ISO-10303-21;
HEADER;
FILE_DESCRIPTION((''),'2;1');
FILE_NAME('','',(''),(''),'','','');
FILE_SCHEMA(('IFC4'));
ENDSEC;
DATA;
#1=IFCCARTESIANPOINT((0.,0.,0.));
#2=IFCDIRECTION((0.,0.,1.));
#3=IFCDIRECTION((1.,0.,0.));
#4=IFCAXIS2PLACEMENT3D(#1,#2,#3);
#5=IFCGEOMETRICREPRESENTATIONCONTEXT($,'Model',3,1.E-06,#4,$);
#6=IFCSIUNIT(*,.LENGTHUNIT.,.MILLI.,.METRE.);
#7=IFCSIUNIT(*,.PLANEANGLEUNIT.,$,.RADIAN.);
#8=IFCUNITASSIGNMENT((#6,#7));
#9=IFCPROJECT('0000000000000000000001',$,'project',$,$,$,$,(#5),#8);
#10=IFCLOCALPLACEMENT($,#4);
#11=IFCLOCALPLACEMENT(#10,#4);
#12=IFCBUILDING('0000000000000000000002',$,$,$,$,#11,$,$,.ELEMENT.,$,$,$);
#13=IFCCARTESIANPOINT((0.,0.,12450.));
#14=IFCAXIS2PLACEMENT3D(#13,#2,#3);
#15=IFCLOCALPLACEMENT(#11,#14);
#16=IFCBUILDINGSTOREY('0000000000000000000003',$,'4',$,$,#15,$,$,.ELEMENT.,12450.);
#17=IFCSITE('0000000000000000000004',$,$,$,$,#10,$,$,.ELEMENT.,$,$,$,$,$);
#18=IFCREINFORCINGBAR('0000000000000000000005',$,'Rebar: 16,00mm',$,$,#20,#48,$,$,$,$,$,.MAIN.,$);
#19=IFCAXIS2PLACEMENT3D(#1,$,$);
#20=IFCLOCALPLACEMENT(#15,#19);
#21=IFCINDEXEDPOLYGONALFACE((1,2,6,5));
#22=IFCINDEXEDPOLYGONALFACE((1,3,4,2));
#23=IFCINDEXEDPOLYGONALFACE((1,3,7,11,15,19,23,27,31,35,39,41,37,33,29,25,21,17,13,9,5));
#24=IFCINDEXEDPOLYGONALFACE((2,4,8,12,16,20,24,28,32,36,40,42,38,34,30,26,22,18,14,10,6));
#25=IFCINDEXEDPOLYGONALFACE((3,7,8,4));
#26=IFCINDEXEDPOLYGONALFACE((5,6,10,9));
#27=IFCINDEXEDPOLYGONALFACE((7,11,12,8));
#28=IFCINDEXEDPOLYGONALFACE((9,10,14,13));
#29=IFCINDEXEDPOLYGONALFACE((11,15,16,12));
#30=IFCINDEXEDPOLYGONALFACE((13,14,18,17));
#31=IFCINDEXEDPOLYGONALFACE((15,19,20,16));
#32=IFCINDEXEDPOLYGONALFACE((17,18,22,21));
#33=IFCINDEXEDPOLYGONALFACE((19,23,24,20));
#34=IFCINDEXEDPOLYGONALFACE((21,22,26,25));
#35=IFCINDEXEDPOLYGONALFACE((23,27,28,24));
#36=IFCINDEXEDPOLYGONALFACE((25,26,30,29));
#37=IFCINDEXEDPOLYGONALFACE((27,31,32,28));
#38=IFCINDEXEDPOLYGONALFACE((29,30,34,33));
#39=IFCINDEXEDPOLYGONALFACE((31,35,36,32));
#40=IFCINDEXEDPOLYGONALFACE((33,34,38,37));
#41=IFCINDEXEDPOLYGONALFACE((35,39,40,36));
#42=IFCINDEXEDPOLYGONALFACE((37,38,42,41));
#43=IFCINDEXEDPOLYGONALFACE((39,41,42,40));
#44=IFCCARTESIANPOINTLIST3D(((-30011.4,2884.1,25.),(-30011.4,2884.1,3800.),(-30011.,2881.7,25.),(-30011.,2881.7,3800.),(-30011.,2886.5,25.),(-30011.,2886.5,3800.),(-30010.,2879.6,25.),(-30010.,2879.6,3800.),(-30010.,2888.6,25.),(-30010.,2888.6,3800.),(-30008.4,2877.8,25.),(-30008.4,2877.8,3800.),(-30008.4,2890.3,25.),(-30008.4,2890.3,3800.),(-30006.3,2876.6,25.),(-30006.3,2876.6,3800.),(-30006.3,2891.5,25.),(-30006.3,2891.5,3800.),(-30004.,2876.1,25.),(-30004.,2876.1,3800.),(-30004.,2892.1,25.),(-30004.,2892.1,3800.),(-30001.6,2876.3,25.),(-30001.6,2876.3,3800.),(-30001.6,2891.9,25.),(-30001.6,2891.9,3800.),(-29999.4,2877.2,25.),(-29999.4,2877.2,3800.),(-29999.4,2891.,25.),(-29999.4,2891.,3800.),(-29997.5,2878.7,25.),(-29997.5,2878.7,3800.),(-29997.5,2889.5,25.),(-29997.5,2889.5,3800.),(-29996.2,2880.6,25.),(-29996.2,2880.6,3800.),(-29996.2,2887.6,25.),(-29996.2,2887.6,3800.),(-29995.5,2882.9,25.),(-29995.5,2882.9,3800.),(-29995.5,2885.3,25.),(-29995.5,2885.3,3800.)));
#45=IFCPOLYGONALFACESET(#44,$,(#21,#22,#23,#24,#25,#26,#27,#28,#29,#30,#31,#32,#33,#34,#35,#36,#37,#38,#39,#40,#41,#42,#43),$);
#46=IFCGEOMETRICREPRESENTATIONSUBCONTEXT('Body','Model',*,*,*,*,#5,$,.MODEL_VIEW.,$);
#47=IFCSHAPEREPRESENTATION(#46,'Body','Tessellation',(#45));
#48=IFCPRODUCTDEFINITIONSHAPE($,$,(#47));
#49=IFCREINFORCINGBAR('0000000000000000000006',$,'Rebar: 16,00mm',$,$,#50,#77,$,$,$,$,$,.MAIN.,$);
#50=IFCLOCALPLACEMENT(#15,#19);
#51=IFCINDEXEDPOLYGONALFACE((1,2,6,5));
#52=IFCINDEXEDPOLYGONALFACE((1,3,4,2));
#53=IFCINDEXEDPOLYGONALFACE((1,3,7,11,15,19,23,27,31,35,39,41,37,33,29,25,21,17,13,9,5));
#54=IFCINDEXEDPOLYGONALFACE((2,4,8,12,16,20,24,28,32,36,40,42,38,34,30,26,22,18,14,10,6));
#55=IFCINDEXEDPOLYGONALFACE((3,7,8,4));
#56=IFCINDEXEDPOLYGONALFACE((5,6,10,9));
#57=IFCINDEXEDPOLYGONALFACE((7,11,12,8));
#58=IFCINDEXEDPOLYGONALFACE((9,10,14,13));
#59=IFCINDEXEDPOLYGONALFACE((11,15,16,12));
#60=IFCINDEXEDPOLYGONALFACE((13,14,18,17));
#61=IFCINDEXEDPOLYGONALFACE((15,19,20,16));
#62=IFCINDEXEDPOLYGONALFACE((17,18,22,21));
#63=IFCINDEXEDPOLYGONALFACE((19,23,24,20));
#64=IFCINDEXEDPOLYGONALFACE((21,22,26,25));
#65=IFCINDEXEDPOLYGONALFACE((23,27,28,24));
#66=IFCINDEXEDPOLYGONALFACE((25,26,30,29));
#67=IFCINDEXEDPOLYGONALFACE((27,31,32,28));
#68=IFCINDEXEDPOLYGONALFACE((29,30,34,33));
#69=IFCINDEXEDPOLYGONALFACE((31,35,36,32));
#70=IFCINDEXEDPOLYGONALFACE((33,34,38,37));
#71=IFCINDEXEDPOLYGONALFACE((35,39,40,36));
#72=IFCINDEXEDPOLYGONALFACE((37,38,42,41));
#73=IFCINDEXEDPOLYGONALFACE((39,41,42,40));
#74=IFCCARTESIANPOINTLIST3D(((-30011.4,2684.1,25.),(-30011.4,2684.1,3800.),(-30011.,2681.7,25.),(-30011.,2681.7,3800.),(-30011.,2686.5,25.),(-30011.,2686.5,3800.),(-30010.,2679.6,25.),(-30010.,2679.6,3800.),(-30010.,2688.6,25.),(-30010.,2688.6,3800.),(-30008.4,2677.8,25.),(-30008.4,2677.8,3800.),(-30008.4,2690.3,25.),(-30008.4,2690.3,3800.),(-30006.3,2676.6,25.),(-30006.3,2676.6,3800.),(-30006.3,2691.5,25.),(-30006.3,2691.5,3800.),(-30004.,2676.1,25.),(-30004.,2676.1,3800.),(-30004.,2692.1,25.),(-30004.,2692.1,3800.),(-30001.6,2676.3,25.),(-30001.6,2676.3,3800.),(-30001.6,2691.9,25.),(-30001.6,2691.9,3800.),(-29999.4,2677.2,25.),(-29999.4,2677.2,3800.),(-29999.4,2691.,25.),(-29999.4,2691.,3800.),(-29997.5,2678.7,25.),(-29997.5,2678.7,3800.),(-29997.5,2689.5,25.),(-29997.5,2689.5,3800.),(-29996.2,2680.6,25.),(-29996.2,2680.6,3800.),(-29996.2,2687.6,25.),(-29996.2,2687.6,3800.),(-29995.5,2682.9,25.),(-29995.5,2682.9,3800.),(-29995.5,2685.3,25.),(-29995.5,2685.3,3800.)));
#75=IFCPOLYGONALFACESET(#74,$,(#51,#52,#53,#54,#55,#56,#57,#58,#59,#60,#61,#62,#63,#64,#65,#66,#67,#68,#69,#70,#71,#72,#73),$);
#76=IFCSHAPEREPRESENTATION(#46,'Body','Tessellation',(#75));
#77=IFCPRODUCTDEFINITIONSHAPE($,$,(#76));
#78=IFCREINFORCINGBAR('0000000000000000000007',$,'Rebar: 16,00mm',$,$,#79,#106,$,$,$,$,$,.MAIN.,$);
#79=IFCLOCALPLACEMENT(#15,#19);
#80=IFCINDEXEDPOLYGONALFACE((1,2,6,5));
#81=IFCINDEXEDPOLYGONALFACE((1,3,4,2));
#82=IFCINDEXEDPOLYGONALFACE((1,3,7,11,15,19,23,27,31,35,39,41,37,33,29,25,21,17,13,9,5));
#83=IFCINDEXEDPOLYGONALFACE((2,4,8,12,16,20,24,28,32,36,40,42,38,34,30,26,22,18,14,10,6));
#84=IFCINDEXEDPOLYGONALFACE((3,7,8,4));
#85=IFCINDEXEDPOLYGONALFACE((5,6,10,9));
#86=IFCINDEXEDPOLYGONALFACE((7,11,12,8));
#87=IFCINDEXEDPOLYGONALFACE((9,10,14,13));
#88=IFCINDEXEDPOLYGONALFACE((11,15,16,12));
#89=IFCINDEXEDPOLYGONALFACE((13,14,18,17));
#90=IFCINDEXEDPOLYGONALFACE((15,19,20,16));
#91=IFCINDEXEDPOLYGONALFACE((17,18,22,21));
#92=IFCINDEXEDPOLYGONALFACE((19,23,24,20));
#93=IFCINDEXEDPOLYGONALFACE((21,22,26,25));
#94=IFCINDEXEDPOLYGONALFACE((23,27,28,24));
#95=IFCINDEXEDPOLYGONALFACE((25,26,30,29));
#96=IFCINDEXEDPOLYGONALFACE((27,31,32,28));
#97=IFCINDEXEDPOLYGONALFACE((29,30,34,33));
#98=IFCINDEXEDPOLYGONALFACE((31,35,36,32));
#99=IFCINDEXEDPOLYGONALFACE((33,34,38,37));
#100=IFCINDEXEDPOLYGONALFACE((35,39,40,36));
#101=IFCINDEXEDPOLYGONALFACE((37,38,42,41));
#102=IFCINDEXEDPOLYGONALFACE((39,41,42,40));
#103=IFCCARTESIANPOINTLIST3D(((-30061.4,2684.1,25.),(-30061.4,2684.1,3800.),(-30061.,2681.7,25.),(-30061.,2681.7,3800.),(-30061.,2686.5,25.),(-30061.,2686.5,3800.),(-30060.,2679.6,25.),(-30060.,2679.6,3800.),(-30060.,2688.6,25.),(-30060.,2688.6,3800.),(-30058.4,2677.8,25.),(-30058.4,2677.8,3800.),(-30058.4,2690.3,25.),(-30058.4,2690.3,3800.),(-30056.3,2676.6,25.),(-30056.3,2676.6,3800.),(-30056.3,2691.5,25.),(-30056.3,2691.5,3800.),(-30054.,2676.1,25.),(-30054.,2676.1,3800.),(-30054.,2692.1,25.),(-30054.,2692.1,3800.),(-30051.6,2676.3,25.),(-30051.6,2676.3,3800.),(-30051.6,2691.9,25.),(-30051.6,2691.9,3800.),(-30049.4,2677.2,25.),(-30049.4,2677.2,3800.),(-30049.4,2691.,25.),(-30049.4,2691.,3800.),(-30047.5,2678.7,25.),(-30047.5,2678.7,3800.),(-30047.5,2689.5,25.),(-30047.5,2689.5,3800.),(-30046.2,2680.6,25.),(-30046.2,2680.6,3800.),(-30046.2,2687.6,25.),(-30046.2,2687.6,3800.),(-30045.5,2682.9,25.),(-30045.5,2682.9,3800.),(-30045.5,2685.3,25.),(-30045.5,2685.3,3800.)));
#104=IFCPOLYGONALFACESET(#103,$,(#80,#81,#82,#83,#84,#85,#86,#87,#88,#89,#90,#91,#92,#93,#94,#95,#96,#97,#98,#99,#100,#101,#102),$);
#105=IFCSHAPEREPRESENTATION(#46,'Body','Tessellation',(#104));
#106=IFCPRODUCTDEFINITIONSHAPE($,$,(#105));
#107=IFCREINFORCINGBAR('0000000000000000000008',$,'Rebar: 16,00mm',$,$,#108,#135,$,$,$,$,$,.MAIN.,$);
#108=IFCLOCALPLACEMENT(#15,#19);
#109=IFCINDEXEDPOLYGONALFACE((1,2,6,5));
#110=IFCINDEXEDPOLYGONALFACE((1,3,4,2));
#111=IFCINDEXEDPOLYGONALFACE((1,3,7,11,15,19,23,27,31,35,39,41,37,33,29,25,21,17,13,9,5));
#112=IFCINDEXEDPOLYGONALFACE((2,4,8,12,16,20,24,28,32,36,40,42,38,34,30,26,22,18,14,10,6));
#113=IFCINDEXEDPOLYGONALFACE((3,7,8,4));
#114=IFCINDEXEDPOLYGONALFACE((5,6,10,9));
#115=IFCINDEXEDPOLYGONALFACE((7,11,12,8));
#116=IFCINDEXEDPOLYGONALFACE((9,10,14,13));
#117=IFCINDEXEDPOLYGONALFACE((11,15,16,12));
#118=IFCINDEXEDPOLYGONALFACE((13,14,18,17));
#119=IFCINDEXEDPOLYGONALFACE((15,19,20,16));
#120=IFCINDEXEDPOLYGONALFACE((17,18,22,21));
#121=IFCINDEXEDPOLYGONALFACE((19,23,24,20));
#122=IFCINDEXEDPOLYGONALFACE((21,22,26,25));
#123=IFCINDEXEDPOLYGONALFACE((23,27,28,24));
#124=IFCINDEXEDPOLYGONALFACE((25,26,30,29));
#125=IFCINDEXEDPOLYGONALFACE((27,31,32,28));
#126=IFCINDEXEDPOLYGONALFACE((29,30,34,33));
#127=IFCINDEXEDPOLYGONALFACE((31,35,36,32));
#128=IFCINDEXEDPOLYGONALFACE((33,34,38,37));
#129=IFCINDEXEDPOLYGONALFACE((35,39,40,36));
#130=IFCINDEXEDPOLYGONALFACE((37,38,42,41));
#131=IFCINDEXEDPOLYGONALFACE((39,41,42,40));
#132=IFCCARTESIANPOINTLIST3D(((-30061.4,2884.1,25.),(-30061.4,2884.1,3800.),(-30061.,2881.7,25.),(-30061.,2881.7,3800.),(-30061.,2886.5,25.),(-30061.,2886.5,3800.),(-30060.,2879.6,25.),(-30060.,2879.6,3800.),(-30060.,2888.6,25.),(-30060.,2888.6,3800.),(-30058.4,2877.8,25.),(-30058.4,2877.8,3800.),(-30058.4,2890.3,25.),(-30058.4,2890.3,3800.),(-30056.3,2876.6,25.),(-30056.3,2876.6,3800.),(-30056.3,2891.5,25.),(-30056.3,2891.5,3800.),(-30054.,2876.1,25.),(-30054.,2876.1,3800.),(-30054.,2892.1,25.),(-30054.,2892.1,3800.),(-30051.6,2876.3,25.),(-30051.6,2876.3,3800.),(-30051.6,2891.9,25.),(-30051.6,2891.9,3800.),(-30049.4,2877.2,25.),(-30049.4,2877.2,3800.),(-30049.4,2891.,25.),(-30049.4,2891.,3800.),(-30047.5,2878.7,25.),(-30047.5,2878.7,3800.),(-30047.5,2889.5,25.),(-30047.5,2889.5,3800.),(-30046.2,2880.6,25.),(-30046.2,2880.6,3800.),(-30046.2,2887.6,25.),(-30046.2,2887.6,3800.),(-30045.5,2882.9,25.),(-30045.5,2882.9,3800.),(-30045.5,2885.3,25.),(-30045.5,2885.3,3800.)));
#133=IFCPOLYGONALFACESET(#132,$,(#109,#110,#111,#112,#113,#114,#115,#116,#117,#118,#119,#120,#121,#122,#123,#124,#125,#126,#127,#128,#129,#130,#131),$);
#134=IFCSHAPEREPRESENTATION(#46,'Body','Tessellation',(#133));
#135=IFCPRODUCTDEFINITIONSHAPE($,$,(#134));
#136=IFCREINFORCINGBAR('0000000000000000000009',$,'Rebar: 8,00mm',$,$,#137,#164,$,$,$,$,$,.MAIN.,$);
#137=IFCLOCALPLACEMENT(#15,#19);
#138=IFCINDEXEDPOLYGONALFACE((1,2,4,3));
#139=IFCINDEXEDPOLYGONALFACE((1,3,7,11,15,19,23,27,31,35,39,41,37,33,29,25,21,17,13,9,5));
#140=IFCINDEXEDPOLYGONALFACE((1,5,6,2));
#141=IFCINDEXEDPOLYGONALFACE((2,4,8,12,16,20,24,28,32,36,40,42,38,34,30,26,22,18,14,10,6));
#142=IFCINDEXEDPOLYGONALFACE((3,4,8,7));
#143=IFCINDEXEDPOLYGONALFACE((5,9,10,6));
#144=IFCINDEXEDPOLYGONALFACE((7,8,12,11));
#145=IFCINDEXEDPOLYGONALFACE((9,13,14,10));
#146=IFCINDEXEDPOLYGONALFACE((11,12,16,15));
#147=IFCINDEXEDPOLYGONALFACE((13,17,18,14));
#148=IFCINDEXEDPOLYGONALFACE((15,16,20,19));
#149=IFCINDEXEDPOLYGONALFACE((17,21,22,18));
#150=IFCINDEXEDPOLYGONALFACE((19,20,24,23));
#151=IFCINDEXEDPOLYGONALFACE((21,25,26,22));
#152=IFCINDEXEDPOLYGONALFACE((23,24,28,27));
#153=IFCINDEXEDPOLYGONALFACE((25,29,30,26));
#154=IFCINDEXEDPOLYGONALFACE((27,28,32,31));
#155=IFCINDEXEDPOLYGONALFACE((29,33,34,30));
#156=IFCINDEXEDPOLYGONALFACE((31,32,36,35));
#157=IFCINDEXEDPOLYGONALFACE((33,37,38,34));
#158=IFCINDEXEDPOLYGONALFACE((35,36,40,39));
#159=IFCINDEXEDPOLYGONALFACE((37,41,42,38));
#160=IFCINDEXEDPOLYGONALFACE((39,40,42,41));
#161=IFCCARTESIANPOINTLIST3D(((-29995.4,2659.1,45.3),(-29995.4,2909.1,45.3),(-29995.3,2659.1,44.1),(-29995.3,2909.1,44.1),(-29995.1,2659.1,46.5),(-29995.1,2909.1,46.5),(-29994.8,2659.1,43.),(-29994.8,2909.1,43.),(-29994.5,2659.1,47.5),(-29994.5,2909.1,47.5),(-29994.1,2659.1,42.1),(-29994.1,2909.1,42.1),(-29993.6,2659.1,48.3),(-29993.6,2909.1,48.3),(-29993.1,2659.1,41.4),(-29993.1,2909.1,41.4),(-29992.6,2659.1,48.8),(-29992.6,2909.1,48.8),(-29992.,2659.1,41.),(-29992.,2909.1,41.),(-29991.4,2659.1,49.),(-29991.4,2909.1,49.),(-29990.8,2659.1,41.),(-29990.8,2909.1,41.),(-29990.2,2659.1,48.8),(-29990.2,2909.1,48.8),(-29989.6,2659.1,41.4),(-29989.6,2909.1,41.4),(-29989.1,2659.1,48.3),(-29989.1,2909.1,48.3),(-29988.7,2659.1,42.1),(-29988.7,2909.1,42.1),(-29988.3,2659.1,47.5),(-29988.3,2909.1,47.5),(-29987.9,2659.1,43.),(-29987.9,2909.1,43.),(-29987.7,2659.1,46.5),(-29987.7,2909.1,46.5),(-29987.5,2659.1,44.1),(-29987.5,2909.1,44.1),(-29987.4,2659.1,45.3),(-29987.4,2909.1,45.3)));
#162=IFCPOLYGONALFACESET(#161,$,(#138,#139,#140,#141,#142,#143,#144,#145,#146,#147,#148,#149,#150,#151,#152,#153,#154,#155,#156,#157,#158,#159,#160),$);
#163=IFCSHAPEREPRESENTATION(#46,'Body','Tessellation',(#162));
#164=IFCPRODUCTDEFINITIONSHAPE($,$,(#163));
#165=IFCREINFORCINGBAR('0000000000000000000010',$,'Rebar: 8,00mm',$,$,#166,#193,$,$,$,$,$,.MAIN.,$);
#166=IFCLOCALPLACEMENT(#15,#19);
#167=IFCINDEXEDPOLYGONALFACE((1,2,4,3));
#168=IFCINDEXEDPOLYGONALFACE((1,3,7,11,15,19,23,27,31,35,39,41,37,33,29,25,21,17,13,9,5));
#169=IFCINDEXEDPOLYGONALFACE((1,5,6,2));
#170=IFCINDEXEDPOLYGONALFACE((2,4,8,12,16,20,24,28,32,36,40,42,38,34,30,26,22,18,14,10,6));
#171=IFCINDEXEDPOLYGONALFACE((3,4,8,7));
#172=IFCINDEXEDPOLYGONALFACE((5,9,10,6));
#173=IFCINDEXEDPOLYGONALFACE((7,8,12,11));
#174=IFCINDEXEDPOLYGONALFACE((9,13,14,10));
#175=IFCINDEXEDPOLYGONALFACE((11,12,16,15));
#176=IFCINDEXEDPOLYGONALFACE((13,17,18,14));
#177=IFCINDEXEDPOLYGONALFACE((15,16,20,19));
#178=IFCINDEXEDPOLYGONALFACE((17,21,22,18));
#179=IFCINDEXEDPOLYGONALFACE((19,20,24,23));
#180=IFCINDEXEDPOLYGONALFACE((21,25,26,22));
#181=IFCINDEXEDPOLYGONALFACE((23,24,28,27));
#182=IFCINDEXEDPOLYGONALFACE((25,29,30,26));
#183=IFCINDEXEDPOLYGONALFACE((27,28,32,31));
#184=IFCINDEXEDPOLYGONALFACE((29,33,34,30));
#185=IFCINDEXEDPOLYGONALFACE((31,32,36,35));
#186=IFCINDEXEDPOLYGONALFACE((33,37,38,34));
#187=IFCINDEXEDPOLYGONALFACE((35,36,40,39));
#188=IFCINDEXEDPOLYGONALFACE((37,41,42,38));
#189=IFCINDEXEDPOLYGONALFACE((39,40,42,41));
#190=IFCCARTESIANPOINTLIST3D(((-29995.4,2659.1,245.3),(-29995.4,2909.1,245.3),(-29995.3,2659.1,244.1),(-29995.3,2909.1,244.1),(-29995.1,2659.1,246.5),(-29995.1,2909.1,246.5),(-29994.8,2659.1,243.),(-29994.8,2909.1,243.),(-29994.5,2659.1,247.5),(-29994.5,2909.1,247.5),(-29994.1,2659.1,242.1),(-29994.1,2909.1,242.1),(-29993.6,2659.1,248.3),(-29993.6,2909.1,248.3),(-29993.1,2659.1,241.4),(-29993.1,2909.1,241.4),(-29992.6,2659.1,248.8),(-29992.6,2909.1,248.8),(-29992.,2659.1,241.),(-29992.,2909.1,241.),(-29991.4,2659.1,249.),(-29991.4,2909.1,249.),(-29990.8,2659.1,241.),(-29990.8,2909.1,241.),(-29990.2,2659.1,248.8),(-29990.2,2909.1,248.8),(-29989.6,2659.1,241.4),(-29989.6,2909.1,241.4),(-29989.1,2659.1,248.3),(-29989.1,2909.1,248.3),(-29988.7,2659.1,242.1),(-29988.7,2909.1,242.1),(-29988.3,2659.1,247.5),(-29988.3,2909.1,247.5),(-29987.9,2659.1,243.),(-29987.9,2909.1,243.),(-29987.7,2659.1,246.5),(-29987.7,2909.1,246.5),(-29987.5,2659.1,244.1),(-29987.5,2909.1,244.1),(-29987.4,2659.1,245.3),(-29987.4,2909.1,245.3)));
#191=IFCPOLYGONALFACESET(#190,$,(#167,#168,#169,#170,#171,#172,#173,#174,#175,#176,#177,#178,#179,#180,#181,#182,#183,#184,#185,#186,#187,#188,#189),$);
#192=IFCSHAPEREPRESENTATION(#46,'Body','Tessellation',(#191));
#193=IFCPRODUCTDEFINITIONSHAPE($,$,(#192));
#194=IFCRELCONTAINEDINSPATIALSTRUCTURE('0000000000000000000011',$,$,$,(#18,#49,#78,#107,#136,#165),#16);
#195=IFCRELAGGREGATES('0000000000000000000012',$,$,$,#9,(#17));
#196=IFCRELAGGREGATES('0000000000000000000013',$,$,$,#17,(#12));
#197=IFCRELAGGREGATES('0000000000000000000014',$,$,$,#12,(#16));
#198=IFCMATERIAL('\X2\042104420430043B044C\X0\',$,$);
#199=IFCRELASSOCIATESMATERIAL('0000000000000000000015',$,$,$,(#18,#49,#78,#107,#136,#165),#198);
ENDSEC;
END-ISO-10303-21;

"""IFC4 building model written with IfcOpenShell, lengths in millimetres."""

from ifc_helpers import new_model, entity, si_unit, frame, origin_with_axes, place, context, subcontext, project, spatial, source, transform, mapped, material, element, save


model = new_model("IFC4")

# Units and contexts
model_context = context("Model", 3, precision=1e-06, world=origin_with_axes())
body_context = subcontext(model_context, "Body", "Model", "MODEL_VIEW")
ifc_project = project(units=[si_unit("LENGTHUNIT", "METRE", prefix="MILLI"), si_unit("PLANEANGLEUNIT", "RADIAN")], contexts=[model_context])

# Site, building, storey
site_placement = place(None, origin_with_axes())
site = spatial("IfcSite", under=ifc_project, at=site_placement, CompositionType="ELEMENT")
building_placement = place(site_placement, origin_with_axes())
building = spatial("IfcBuilding", under=site, at=building_placement, CompositionType="ELEMENT")
storey_placement = place(building_placement, frame((0.0, 0.0, 12450.0), z_axis=(0.0, 0.0, 1.0), x_axis=(1.0, 0.0, 0.0)))
storey = spatial("IfcBuildingStorey", under=building, at=storey_placement, Name="4", CompositionType="ELEMENT", Elevation=12450.0)

# Reinforcing bars
ifc_material = material(Name="Сталь")
shared_shape_1 = source(origin_with_axes(), body_context, "Body", "AdvancedSweptSolid", [
    entity("IfcSweptDiskSolid", entity("IfcIndexedPolyCurve", entity("IfcCartesianPointList3D", [[0.0, 0.0, 0.0], [3775.0, 0.0, 0.0]]), [entity("IfcLineIndex", [1, 2])]), 8.0),
])
reinforcing_bar_1_placement = place(storey_placement, origin_with_axes())
element("IfcReinforcingBar", 1, at=reinforcing_bar_1_placement, inside=storey, material=ifc_material, Name="Rebar: 16,00mm", PredefinedType="MAIN", context=body_context, shape_type="MappedRepresentation", body=[
    mapped(shared_shape_1, transform((-30003.4, 2884.1, 25.0), x_axis=(0.0, 0.0, 1.0), y_axis=(0.0, 1.0, 0.0), z_axis=(-1.0, 0.0, 0.0), scale=1.0)),
])
reinforcing_bar_2_placement = place(storey_placement, origin_with_axes())
element("IfcReinforcingBar", 2, at=reinforcing_bar_2_placement, inside=storey, material=ifc_material, Name="Rebar: 16,00mm", PredefinedType="MAIN", context=body_context, shape_type="MappedRepresentation", body=[
    mapped(shared_shape_1, transform((-30003.4, 2684.1, 25.0), x_axis=(0.0, 0.0, 1.0), y_axis=(0.0, 1.0, 0.0), z_axis=(-1.0, 0.0, 0.0), scale=1.0)),
])
reinforcing_bar_3_placement = place(storey_placement, origin_with_axes())
element("IfcReinforcingBar", 3, at=reinforcing_bar_3_placement, inside=storey, material=ifc_material, Name="Rebar: 16,00mm", PredefinedType="MAIN", context=body_context, shape_type="MappedRepresentation", body=[
    mapped(shared_shape_1, transform((-30053.4, 2684.1, 25.0), x_axis=(0.0, 0.0, 1.0), y_axis=(0.0, 1.0, 0.0), z_axis=(-1.0, 0.0, 0.0), scale=1.0)),
])
reinforcing_bar_4_placement = place(storey_placement, origin_with_axes())
element("IfcReinforcingBar", 4, at=reinforcing_bar_4_placement, inside=storey, material=ifc_material, Name="Rebar: 16,00mm", PredefinedType="MAIN", context=body_context, shape_type="MappedRepresentation", body=[
    mapped(shared_shape_1, transform((-30053.4, 2884.1, 25.0), x_axis=(0.0, 0.0, 1.0), y_axis=(0.0, 1.0, 0.0), z_axis=(-1.0, 0.0, 0.0), scale=1.0)),
])
shared_shape_2 = source(origin_with_axes(), body_context, "Body", "AdvancedSweptSolid", [
    entity("IfcSweptDiskSolid", entity("IfcIndexedPolyCurve", entity("IfcCartesianPointList3D", [[0.0, 0.0, 0.0], [250.0, 0.0, 0.0]]), [entity("IfcLineIndex", [1, 2])]), 4.0),
])
reinforcing_bar_5_placement = place(storey_placement, origin_with_axes())
element("IfcReinforcingBar", 5, at=reinforcing_bar_5_placement, inside=storey, material=ifc_material, Name="Rebar: 8,00mm", PredefinedType="MAIN", context=body_context, shape_type="MappedRepresentation", body=[
    mapped(shared_shape_2, transform((-29991.4, 2909.1, 45.0), x_axis=(0.0, -1.0, 0.0), y_axis=(1.0, 0.0, 0.0), z_axis=(0.0, 0.0, 1.0), scale=1.0)),
])
reinforcing_bar_6_placement = place(storey_placement, origin_with_axes())
element("IfcReinforcingBar", 6, at=reinforcing_bar_6_placement, inside=storey, material=ifc_material, Name="Rebar: 8,00mm", PredefinedType="MAIN", context=body_context, shape_type="MappedRepresentation", body=[
    mapped(shared_shape_2, transform((-29991.4, 2909.1, 245.0), x_axis=(0.0, -1.0, 0.0), y_axis=(1.0, 0.0, 0.0), z_axis=(0.0, 0.0, 1.0), scale=1.0)),
])

save(model, "model.ifc")
